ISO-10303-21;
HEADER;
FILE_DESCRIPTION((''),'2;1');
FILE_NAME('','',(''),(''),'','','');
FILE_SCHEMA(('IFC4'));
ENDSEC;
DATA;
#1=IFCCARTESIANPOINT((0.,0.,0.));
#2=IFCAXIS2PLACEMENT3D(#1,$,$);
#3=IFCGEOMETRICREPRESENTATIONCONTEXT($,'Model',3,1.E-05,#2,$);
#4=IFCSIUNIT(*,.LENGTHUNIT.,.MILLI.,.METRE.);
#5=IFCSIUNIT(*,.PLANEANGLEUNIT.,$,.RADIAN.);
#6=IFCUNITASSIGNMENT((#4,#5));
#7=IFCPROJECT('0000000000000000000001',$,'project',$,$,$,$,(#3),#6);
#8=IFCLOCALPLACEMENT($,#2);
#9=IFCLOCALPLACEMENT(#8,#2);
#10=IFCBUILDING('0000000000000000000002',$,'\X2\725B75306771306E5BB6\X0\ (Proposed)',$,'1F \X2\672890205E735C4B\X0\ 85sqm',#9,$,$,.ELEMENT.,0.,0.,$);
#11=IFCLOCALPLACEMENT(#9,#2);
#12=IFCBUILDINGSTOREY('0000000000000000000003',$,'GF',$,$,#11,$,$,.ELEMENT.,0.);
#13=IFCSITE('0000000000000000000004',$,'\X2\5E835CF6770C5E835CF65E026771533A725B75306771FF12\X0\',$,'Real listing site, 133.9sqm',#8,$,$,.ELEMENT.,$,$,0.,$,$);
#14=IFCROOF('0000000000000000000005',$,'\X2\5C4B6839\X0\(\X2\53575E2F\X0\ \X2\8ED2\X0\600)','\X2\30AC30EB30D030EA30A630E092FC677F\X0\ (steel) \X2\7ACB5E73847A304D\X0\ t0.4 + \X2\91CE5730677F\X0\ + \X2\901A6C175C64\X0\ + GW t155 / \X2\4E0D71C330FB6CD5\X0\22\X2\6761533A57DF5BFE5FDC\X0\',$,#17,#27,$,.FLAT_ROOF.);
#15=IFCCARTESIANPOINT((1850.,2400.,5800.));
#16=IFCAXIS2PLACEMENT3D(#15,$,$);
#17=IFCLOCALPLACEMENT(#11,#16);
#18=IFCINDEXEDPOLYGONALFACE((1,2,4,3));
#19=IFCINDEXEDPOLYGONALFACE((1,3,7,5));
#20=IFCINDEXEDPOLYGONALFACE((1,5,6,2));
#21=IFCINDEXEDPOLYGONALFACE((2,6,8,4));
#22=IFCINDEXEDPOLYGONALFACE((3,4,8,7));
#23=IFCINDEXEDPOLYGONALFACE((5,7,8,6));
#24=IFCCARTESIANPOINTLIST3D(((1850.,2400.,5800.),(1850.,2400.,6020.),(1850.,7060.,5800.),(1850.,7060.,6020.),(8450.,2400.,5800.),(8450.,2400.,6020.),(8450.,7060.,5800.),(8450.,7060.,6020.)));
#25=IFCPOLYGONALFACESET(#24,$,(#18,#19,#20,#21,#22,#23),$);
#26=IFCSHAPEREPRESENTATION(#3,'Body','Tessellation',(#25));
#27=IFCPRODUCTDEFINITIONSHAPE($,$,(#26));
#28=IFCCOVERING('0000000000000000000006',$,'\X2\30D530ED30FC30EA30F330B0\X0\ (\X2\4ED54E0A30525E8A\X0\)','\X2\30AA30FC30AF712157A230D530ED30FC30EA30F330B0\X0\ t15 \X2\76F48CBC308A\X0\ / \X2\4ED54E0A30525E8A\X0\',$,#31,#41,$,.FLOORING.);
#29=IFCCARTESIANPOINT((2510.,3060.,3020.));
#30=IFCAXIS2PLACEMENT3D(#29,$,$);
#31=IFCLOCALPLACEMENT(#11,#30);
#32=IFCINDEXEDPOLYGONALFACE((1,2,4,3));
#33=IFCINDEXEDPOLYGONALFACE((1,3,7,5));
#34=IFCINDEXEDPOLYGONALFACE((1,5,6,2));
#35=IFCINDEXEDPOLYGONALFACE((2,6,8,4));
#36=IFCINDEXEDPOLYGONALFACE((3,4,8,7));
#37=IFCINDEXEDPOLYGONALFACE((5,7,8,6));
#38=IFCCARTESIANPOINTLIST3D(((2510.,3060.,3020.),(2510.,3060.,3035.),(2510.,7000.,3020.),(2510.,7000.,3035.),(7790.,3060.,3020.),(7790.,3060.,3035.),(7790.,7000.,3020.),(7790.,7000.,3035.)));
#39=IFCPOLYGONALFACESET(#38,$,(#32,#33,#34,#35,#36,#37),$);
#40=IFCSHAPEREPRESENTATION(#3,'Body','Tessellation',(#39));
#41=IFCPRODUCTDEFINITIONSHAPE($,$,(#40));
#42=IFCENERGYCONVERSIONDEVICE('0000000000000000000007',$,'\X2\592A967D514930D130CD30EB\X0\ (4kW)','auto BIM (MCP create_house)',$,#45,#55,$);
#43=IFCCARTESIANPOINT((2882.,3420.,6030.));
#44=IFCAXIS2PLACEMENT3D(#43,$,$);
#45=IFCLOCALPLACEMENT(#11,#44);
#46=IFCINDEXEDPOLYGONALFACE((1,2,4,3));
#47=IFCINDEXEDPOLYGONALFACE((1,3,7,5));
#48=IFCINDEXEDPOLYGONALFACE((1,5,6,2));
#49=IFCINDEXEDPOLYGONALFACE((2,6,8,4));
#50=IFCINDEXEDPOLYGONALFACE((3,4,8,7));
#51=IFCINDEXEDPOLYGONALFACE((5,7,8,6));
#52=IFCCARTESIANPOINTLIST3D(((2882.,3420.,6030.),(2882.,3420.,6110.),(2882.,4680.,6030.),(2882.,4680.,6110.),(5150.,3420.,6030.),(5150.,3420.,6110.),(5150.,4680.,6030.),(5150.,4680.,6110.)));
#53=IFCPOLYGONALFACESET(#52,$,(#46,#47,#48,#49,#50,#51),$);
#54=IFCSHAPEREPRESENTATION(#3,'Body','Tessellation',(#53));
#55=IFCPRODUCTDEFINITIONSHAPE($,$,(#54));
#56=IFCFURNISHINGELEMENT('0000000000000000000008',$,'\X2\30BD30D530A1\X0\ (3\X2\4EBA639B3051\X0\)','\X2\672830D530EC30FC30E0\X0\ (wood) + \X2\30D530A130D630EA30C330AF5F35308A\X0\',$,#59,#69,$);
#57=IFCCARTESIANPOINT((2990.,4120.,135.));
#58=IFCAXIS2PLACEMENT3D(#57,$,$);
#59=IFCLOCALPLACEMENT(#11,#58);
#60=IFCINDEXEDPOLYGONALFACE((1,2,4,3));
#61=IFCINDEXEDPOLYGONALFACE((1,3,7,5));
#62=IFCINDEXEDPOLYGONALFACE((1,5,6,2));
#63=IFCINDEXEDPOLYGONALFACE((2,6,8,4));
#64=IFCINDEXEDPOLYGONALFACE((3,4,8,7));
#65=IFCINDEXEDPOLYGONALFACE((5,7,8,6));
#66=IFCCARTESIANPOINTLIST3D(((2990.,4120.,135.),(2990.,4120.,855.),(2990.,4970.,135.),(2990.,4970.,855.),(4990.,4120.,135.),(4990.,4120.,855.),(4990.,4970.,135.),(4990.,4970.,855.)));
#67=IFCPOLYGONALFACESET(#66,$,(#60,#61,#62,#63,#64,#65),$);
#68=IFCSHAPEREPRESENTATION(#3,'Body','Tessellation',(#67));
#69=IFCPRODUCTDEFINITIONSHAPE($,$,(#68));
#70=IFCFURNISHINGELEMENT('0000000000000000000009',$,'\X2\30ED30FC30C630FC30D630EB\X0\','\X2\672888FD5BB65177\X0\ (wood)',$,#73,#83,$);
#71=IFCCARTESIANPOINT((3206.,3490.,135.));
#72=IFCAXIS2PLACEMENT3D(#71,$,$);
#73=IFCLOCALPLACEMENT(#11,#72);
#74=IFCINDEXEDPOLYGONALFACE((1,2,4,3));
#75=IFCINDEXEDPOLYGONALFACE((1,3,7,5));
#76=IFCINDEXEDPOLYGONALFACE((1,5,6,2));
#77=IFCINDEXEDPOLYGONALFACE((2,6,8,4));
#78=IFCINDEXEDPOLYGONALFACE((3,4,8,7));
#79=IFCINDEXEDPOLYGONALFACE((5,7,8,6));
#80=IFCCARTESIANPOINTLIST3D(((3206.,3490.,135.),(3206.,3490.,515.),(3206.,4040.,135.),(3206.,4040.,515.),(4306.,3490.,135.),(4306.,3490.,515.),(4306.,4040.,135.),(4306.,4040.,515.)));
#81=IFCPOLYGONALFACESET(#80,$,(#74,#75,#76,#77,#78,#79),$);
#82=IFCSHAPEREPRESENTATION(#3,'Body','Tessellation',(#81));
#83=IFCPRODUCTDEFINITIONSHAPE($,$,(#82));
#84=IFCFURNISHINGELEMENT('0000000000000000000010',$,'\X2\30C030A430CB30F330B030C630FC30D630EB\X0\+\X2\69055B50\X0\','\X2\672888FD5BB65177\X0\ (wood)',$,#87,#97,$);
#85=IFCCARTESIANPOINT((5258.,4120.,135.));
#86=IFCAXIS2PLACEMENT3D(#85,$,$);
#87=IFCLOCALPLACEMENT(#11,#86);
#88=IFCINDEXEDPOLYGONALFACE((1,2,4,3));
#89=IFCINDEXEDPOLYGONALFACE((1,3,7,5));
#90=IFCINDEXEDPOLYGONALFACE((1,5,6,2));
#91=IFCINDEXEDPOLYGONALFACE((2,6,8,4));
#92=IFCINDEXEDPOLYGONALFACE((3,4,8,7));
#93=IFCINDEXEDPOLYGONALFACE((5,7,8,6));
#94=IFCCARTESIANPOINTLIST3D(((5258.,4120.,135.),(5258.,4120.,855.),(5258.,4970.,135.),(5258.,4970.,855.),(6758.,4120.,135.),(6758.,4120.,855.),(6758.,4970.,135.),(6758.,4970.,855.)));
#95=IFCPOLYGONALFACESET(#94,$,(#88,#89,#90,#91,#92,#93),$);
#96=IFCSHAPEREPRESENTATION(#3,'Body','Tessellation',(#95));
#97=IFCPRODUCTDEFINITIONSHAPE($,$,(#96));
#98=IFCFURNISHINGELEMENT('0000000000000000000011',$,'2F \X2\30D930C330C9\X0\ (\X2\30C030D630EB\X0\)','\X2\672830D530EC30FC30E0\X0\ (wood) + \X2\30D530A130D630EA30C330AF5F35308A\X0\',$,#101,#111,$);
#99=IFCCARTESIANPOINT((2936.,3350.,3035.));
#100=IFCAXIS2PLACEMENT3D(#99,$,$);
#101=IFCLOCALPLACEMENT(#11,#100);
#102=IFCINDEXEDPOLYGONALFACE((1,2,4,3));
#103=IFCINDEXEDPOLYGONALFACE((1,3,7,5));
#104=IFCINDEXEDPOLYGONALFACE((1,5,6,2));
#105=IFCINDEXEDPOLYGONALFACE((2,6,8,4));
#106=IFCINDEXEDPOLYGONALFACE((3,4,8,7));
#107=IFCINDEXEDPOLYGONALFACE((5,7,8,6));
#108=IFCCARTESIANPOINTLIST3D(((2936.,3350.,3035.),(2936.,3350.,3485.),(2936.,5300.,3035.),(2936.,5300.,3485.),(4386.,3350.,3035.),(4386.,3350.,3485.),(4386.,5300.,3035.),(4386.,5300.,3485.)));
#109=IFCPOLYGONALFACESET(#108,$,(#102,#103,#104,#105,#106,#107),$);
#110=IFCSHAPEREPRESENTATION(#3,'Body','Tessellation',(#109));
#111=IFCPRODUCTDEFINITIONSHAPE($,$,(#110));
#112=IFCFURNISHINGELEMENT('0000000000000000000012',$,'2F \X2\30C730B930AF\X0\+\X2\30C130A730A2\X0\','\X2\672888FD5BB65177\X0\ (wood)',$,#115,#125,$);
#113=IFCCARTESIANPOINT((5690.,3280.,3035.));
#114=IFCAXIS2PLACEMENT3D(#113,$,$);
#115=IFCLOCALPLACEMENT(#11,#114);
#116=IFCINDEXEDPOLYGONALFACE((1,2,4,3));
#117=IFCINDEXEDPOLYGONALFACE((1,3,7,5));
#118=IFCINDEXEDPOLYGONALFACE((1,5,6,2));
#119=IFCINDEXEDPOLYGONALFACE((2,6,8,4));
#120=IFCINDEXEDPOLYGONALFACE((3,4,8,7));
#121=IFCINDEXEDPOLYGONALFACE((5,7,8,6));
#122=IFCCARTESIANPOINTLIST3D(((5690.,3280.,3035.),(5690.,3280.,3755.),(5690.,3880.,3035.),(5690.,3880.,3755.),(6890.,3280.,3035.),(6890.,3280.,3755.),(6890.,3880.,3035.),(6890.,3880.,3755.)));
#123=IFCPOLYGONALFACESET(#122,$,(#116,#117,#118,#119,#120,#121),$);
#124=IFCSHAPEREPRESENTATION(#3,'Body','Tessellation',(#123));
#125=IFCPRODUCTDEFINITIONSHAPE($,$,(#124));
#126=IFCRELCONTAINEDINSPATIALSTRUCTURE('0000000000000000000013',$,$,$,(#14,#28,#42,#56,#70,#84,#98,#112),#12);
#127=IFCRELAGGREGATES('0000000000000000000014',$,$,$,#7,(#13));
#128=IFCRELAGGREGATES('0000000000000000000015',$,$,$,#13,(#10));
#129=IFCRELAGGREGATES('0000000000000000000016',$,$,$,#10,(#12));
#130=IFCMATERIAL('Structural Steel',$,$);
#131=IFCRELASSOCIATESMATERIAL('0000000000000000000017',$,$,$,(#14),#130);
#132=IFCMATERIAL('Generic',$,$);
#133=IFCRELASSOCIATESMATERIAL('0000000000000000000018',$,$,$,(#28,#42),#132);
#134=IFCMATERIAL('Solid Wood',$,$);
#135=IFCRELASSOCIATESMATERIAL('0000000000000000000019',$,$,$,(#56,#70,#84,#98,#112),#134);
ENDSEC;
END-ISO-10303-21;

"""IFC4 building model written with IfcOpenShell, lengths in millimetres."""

from ifc_helpers import new_model, si_unit, frame, frame_2d, origin, place, context, project, spatial, rectangle, extrude, material, element, save


model = new_model("IFC4")

# Units and contexts
model_context = context("Model", 3, precision=1e-05, world=origin())
ifc_project = project(units=[si_unit("LENGTHUNIT", "METRE", prefix="MILLI"), si_unit("PLANEANGLEUNIT", "RADIAN")], contexts=[model_context])

# Site, building, storey
site_placement = place(None, origin())
site = spatial("IfcSite", under=ifc_project, at=site_placement, Name="広島県広島市東区牛田東２", ObjectType="Real listing site, 133.9sqm", CompositionType="ELEMENT", RefElevation=0.0)
building_placement = place(site_placement, origin())
building = spatial("IfcBuilding", under=site, at=building_placement, Name="牛田東の家 (Proposed)", ObjectType="1F 木造平屋 85sqm", CompositionType="ELEMENT", ElevationOfRefHeight=0.0, ElevationOfTerrain=0.0)
storey_placement = place(building_placement, origin())
storey = spatial("IfcBuildingStorey", under=building, at=storey_placement, Name="GF", CompositionType="ELEMENT", Elevation=0.0)

# Shared definitions
ifc_material_1 = material(Name="Solid Wood")

# Shared definitions
ifc_material_2 = material(Name="Generic")

# Roof
ifc_material_3 = material(Name="Structural Steel")
for number, where, name in (
    (1, (1850.0, 2400.0, 5800.0), "屋根(南帯 軒600)"),
):
    element("IfcRoof", number, at=place(storey_placement, frame(where)), inside=storey, material=ifc_material_3, Name=name, Description="ガルバリウム鋼板 (steel) 立平葺き t0.4 + 野地板 + 通気層 + GW t155 / 不燃・法22条区域対応", PredefinedType="FLAT_ROOF", context=model_context, shape_type="SweptSolid", body=[
        extrude(rectangle(XDim=6600.0, YDim=4660.0, at=frame_2d((3300.0, 2330.0))), frame((1850.0, 2400.0, 5800.0)), (0.0, 0.0, 1.0), 220.0),
    ])

# Covering
covering_placement = place(storey_placement, frame((2510.0, 3060.0, 3020.0)))
element("IfcCovering", 2, at=covering_placement, inside=storey, material=ifc_material_2, Name="フローリング (仕上げ床)", Description="オーク無垢フローリング t15 直貼り / 仕上げ床", PredefinedType="FLOORING", context=model_context, shape_type="SweptSolid", body=[
    extrude(rectangle(XDim=5280.0, YDim=3940.0, at=frame_2d((2640.0, 1970.0))), frame((2510.0, 3060.0, 3020.0)), (0.0, 0.0, 1.0), 15.0),
])

# Energy conversion device
energy_conversion_device_placement = place(storey_placement, frame((2882.0, 3420.0, 6030.0)))
element("IfcEnergyConversionDevice", 3, at=energy_conversion_device_placement, inside=storey, material=ifc_material_2, Name="太陽光パネル (4kW)", Description="auto BIM (MCP create_house)", context=model_context, shape_type="SweptSolid", body=[
    extrude(rectangle(XDim=2268.0, YDim=1260.0, at=frame_2d((1134.0, 630.0))), frame((2882.0, 3420.0, 6030.0)), (0.0, 0.0, 1.0), 80.0),
])

# Furnishing elements
furnishing_1_placement = place(storey_placement, frame((2990.0, 4120.0, 135.0)))
element("IfcFurnishingElement", 4, at=furnishing_1_placement, inside=storey, material=ifc_material_1, Name="ソファ (3人掛け)", Description="木フレーム (wood) + ファブリック張り", context=model_context, shape_type="SweptSolid", body=[
    extrude(rectangle(XDim=2000.0, YDim=850.0, at=frame_2d((1000.0, 425.0))), frame((2990.0, 4120.0, 135.0)), (0.0, 0.0, 1.0), 720.0),
])
furnishing_2_placement = place(storey_placement, frame((3206.0, 3490.0, 135.0)))
element("IfcFurnishingElement", 5, at=furnishing_2_placement, inside=storey, material=ifc_material_1, Name="ローテーブル", Description="木製家具 (wood)", context=model_context, shape_type="SweptSolid", body=[
    extrude(rectangle(XDim=1100.0, YDim=550.0, at=frame_2d((550.0, 275.0))), frame((3206.0, 3490.0, 135.0)), (0.0, 0.0, 1.0), 380.0),
])
furnishing_3_placement = place(storey_placement, frame((5258.0, 4120.0, 135.0)))
element("IfcFurnishingElement", 6, at=furnishing_3_placement, inside=storey, material=ifc_material_1, Name="ダイニングテーブル+椅子", Description="木製家具 (wood)", context=model_context, shape_type="SweptSolid", body=[
    extrude(rectangle(XDim=1500.0, YDim=850.0, at=frame_2d((750.0, 425.0))), frame((5258.0, 4120.0, 135.0)), (0.0, 0.0, 1.0), 720.0),
])
furnishing_4_placement = place(storey_placement, frame((2936.0, 3350.0, 3035.0)))
element("IfcFurnishingElement", 7, at=furnishing_4_placement, inside=storey, material=ifc_material_1, Name="2F ベッド (ダブル)", Description="木フレーム (wood) + ファブリック張り", context=model_context, shape_type="SweptSolid", body=[
    extrude(rectangle(XDim=1450.0, YDim=1950.0, at=frame_2d((725.0, 975.0))), frame((2936.0, 3350.0, 3035.0)), (0.0, 0.0, 1.0), 450.0),
])
furnishing_5_placement = place(storey_placement, frame((5690.0, 3280.0, 3035.0)))
element("IfcFurnishingElement", 8, at=furnishing_5_placement, inside=storey, material=ifc_material_1, Name="2F デスク+チェア", Description="木製家具 (wood)", context=model_context, shape_type="SweptSolid", body=[
    extrude(rectangle(XDim=1200.0, YDim=600.0, at=frame_2d((600.0, 300.0))), frame((5690.0, 3280.0, 3035.0)), (0.0, 0.0, 1.0), 720.0),
])

save(model, "model.ifc")
